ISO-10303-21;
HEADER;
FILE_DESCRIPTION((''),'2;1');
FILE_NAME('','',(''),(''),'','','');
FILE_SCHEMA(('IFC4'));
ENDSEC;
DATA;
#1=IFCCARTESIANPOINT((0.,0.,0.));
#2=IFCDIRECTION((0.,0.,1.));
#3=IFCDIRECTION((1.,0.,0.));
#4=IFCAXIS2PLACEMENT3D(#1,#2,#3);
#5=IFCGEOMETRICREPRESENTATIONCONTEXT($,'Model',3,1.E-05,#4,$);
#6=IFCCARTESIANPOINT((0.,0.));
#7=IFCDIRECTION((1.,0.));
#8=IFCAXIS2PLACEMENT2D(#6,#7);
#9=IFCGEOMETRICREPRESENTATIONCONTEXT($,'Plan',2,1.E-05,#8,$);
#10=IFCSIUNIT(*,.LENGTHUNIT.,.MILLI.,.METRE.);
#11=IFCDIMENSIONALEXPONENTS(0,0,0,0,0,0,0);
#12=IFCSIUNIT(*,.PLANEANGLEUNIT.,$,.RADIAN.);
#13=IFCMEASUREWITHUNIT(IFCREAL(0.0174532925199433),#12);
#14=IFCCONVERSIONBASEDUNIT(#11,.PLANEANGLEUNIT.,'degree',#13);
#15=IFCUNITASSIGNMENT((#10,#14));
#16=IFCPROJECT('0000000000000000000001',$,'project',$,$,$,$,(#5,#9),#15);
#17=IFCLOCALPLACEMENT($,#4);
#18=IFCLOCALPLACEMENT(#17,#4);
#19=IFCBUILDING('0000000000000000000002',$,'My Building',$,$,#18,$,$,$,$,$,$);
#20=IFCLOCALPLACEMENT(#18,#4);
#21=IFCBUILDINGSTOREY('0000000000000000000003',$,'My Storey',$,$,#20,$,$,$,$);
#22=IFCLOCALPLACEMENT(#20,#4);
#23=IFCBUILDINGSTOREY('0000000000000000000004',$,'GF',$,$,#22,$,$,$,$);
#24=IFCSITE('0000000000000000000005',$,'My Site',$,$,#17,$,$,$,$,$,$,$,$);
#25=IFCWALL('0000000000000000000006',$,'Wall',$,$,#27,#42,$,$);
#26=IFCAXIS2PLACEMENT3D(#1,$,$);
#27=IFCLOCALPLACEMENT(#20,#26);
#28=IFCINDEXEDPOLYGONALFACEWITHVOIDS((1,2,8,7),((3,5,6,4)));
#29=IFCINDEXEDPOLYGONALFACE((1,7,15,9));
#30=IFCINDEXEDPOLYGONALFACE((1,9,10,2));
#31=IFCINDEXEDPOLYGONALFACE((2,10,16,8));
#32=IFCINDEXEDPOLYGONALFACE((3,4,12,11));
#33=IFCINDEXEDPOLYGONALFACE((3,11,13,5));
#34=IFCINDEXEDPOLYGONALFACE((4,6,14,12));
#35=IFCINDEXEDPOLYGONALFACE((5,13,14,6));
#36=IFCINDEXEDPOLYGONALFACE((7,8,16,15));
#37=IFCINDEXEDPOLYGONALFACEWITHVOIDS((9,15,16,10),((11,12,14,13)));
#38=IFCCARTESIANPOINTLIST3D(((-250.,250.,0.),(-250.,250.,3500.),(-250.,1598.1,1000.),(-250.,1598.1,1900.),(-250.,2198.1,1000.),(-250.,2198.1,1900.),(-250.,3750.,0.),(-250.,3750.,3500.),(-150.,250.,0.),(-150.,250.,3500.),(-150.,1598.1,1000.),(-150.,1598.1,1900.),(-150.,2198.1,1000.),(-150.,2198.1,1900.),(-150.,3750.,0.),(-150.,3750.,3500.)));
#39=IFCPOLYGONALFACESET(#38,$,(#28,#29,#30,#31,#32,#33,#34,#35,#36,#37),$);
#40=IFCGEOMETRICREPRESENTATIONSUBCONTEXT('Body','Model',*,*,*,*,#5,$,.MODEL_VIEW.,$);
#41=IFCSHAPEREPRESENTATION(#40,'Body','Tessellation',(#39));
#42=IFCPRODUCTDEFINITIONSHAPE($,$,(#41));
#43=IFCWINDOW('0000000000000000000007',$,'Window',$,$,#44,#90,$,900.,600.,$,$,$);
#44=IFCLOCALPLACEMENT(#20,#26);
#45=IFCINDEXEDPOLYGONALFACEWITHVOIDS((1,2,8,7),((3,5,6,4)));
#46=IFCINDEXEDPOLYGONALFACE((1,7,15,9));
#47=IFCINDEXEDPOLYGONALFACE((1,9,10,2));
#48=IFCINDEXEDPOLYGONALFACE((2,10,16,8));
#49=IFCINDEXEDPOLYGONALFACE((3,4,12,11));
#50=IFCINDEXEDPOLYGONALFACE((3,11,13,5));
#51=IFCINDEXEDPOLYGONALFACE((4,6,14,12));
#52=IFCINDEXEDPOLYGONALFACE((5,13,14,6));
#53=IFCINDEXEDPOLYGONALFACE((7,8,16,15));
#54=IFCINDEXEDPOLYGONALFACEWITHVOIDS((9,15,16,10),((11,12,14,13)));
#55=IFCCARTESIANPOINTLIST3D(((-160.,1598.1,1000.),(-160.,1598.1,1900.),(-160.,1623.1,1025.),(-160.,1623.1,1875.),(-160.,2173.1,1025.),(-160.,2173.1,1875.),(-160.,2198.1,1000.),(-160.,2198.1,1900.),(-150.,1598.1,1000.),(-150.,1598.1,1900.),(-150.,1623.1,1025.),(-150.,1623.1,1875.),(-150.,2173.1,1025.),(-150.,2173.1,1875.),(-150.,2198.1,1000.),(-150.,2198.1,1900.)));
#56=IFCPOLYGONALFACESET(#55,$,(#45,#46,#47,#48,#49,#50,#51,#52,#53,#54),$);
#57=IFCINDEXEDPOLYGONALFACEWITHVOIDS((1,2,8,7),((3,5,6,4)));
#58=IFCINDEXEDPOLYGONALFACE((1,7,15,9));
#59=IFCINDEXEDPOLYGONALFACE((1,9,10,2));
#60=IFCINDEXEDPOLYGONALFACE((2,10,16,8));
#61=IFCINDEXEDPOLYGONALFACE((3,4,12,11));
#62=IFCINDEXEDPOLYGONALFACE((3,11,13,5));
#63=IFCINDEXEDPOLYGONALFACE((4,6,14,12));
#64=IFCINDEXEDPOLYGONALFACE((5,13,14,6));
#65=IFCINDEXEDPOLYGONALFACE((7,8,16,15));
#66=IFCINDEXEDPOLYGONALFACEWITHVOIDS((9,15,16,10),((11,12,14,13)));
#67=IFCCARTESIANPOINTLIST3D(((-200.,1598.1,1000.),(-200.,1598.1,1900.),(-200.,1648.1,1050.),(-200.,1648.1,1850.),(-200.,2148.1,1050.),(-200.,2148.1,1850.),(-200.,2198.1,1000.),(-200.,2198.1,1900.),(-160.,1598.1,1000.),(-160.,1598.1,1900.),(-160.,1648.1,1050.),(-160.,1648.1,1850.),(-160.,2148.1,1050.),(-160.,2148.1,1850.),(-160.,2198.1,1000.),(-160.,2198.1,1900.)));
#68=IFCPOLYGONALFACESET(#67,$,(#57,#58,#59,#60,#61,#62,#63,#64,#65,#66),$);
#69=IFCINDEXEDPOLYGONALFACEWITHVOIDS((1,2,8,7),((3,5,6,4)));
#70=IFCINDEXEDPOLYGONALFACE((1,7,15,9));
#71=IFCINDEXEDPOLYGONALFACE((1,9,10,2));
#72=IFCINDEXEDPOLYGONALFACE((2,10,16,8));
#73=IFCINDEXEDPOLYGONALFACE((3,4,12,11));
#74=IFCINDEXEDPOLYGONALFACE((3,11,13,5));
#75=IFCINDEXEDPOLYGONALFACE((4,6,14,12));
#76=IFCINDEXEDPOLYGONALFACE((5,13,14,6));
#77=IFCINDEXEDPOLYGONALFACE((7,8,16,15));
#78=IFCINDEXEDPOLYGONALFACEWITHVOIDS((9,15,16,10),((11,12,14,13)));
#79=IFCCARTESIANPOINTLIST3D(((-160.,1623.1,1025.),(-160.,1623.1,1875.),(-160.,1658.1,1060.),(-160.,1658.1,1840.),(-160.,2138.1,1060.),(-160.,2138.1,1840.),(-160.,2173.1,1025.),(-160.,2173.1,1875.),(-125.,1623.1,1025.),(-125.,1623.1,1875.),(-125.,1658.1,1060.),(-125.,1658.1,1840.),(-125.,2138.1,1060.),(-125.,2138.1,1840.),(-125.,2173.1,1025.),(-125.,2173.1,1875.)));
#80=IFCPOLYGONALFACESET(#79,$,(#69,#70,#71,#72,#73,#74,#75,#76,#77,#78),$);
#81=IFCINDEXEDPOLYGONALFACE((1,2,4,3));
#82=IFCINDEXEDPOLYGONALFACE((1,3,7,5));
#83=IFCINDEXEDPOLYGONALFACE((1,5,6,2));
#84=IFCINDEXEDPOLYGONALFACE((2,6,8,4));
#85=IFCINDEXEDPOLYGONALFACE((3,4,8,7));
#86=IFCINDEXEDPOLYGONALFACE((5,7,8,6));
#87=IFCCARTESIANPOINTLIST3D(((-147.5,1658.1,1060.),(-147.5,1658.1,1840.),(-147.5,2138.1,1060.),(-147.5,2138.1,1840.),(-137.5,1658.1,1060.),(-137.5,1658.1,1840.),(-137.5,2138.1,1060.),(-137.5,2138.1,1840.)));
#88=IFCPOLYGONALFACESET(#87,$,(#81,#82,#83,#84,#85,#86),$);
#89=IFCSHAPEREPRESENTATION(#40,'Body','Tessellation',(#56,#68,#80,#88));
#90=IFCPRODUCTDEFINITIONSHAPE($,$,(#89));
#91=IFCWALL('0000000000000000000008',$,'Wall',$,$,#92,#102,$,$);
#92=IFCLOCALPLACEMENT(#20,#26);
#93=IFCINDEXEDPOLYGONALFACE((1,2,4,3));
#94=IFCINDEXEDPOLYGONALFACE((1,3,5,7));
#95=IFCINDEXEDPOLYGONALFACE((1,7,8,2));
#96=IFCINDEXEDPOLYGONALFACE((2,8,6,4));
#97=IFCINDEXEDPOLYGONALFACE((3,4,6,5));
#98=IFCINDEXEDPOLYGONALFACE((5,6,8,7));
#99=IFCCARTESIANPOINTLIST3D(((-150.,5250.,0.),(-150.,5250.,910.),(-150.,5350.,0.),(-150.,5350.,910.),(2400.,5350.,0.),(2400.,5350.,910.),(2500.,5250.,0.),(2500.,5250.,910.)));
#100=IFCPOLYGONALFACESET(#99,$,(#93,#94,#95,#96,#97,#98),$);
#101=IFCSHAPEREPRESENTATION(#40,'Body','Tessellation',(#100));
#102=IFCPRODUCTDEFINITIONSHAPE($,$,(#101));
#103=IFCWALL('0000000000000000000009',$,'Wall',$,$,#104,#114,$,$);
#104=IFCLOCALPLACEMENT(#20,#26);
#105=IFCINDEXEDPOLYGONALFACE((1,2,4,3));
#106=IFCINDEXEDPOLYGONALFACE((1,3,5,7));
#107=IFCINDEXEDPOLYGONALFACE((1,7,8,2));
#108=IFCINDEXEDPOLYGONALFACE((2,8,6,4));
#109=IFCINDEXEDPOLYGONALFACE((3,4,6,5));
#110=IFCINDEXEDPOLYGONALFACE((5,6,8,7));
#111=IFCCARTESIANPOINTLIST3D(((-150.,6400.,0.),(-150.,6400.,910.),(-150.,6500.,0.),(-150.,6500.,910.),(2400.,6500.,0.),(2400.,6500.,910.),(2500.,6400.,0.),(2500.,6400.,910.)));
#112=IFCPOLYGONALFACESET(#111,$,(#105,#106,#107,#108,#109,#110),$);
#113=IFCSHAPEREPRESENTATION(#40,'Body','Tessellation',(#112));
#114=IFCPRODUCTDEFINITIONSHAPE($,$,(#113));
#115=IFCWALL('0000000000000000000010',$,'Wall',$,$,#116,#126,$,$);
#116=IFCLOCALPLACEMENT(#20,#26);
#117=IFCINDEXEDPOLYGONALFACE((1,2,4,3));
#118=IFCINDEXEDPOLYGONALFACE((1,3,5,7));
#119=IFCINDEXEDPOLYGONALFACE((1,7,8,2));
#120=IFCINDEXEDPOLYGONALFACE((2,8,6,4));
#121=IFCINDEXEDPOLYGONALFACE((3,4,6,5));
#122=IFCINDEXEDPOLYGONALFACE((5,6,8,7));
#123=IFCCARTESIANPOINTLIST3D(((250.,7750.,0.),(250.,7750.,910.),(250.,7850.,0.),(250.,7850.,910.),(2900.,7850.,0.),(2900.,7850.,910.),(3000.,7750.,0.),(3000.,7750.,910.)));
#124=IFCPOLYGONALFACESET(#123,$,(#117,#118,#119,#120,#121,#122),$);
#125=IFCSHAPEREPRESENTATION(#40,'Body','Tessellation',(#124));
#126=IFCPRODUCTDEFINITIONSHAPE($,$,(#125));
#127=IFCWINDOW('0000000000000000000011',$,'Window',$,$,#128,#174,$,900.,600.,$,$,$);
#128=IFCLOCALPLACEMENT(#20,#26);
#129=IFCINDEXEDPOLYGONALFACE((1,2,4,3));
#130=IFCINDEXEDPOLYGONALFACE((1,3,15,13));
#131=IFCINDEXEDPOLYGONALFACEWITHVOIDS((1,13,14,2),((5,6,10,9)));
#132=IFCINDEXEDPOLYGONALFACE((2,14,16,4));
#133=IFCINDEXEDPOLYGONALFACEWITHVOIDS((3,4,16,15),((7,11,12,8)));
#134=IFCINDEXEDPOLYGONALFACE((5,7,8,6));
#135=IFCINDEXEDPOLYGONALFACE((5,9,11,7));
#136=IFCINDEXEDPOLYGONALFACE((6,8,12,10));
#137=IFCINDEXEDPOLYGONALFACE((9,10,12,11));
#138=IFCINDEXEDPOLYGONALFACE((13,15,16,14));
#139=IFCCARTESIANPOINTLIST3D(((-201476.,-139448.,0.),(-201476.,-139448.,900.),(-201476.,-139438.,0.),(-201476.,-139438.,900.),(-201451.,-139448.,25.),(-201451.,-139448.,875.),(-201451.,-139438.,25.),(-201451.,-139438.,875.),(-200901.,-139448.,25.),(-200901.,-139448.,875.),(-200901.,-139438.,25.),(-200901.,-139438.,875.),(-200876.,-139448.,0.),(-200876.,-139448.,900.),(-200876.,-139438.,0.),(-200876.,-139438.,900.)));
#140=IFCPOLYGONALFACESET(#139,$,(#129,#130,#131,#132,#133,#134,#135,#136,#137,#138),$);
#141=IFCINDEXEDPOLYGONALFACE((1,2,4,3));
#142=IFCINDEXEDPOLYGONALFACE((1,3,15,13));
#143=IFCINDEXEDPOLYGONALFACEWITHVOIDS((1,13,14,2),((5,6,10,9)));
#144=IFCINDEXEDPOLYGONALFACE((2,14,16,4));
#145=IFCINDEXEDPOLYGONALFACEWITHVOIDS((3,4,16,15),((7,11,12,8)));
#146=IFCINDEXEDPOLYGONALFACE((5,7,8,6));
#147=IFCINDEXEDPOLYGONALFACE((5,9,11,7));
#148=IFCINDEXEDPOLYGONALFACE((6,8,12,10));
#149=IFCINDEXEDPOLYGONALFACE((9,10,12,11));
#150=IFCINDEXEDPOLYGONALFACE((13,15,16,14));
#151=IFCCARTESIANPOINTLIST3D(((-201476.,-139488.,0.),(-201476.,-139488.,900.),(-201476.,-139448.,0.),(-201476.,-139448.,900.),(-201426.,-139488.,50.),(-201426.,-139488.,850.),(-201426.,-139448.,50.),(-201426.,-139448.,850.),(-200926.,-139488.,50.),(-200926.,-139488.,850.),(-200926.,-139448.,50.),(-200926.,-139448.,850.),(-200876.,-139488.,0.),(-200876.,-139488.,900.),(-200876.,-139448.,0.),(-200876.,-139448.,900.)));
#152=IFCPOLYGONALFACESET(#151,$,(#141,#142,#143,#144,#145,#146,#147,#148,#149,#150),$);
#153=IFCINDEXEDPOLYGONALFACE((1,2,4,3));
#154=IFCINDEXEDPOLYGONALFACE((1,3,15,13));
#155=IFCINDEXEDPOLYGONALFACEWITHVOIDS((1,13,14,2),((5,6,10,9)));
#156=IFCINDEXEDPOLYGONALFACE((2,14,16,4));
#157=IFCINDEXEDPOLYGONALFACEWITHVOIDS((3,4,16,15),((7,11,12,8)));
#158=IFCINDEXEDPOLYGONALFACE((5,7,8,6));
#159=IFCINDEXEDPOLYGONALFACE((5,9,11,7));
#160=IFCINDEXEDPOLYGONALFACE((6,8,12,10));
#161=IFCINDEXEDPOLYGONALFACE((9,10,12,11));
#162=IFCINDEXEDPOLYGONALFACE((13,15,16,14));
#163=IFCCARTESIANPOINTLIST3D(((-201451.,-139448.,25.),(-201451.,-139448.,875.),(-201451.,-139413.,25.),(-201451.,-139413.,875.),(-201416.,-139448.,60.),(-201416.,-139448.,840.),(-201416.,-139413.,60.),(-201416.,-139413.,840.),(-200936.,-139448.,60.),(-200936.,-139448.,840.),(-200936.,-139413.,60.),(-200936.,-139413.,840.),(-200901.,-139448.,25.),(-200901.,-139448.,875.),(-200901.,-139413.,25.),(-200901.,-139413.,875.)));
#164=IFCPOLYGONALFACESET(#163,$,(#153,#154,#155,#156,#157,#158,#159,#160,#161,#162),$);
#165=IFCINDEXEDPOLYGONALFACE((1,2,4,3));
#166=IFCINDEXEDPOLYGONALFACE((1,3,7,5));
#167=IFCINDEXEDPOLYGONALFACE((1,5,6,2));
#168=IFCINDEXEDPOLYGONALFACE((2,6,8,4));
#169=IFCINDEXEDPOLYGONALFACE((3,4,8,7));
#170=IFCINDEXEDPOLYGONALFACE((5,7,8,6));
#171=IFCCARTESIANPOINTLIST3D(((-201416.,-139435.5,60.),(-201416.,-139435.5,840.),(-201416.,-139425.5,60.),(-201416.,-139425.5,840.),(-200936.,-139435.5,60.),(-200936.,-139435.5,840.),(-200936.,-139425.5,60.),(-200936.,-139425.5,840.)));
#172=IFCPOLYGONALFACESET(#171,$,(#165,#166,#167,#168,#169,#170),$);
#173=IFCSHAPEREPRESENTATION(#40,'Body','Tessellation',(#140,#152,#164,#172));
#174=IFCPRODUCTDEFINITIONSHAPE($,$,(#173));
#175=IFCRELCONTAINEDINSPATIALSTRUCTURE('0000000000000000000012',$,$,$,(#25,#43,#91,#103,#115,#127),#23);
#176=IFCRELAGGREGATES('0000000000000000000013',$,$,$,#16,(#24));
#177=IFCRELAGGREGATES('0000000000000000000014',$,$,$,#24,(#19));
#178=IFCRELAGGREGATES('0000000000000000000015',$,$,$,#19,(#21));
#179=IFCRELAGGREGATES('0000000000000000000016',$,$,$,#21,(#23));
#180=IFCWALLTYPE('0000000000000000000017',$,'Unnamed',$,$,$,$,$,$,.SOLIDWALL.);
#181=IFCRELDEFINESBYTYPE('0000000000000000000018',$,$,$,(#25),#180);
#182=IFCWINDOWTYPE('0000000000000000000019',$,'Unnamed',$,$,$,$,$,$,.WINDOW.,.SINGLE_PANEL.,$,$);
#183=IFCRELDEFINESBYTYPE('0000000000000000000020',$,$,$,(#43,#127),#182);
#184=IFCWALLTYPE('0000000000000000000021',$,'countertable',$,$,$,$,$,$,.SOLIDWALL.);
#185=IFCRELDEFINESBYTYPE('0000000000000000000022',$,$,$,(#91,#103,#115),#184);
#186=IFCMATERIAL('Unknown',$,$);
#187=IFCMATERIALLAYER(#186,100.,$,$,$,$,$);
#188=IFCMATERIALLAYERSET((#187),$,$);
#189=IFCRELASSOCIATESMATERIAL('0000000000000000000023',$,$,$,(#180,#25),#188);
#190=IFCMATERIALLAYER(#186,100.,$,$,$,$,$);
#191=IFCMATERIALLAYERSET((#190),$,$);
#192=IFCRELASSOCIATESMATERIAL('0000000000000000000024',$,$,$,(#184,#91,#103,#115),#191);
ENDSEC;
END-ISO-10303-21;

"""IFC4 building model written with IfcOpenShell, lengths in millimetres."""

from ifc_helpers import new_model, entity, si_unit, converted_unit, frame, origin_with_axes, origin_2d_with_axis, place, context, subcontext, project, spatial, line, indexed_curve, outline, extrude, shape, source, transform, mapped, material, layer, layer_set, layer_usage, type_object, type_shapes, element, fill, save


model = new_model("IFC4")

# Units and contexts
model_context = context("Model", 3, precision=1e-05, world=origin_with_axes())
plan_context = context("Plan", 2, precision=1e-05, world=origin_2d_with_axis())
body_context_1 = subcontext(model_context, "Body", "Model", "MODEL_VIEW")
body_context_2 = subcontext(plan_context, "Body", "Plan", "PLAN_VIEW")
ifc_project = project(units=[si_unit("LENGTHUNIT", "METRE", prefix="MILLI"), converted_unit("PLANEANGLEUNIT", "degree", entity("IfcReal", 0.0174532925199433), si_unit("PLANEANGLEUNIT", "RADIAN"), dimensions=[0, 0, 0, 0, 0, 0, 0])], contexts=[model_context, plan_context])

# Site, building, storeys
site_placement = place(None, origin_with_axes())
site = spatial("IfcSite", under=ifc_project, at=site_placement, Name="My Site")
building_placement = place(site_placement, origin_with_axes())
building = spatial("IfcBuilding", under=site, at=building_placement, Name="My Building")
storey_1_placement = place(building_placement, origin_with_axes())
storey_1 = spatial("IfcBuildingStorey", under=building, at=storey_1_placement, Name="My Storey")
storey_2_placement = place(storey_1_placement, origin_with_axes())
storey_2 = spatial("IfcBuildingStorey", under=storey_1, at=storey_2_placement, Name="GF")

# Shared definitions
ifc_material = material(Name="Unknown")

# Shared definitions
ifc_layer_1 = layer(ifc_material, 100.0)
ifc_layer_set_1 = layer_set([ifc_layer_1])
wall_type_1 = type_object("IfcWallType", Name="Unnamed", PredefinedType="SOLIDWALL", material=ifc_layer_set_1)

# Shared definitions
shared_shape_1 = source(origin_with_axes(), body_context_1, "Body", "SweptSolid", [
    extrude(outline(indexed_curve([(0.0, 0.0), (600.0, 0.0), (600.0, 900.0), (0.0, 900.0)], segments=[line(1, 2, 3, 4, 1)])), frame((0.0, -600.0, 0.0), z_axis=(0.0, -1.0, 0.0), x_axis=(1.0, 0.0, 0.0)), (0.0, 0.0, -1.0), 1200.0),
])
window_type = type_object("IfcWindowType", Name="Unnamed", PartitioningType="SINGLE_PANEL", PredefinedType="WINDOW")
shared_shape_2 = source(origin_with_axes(), body_context_1, "Body", "SweptSolid", [
    extrude(outline(indexed_curve([(0.0, 0.0), (600.0, 0.0), (600.0, 900.0), (0.0, 900.0)], segments=[line(1, 2, 3, 4, 1)]), holes=[indexed_curve([(25.0, 25.0), (575.0, 25.0), (575.0, 875.0), (25.0, 875.0)], segments=[line(1, 2, 3, 4, 1)])]), frame((0.0, 90.0, 0.0), z_axis=(0.0, -1.0, 0.0), x_axis=(1.0, 0.0, 0.0)), (0.0, 0.0, -1.0), 10.0),
    extrude(outline(indexed_curve([(0.0, 0.0), (600.0, 0.0), (600.0, 900.0), (0.0, 900.0)], segments=[line(1, 2, 3, 4, 1)]), holes=[indexed_curve([(50.0, 50.0), (550.0, 50.0), (550.0, 850.0), (50.0, 850.0)], segments=[line(1, 2, 3, 4, 1)])]), frame((0.0, 50.0, 0.0), z_axis=(0.0, -1.0, 0.0), x_axis=(1.0, 0.0, 0.0)), (0.0, 0.0, -1.0), 40.0),
    extrude(outline(indexed_curve([(0.0, 0.0), (550.0, 0.0), (550.0, 850.0), (0.0, 850.0)], segments=[line(1, 2, 3, 4, 1)]), holes=[indexed_curve([(35.0, 35.0), (515.0, 35.0), (515.0, 815.0), (35.0, 815.0)], segments=[line(1, 2, 3, 4, 1)])]), frame((25.0, 90.0, 25.0), z_axis=(0.0, -1.0, 0.0), x_axis=(1.0, 0.0, 0.0)), (0.0, 0.0, -1.0), 35.0),
    extrude(outline(indexed_curve([(35.0, 35.0), (515.0, 35.0), (515.0, 815.0), (35.0, 815.0)], segments=[line(1, 2, 3, 4, 1)])), frame((25.0, 102.5, 25.0), z_axis=(0.0, -1.0, 0.0), x_axis=(1.0, 0.0, 0.0)), (0.0, 0.0, -1.0), 10.0),
])
shared_shape_3 = source(origin_with_axes(), body_context_2, "Body", "Curve2D", [
    entity("IfcIndexedPolyCurve", entity("IfcCartesianPointList2D", [[50.0, 50.0], [550.0, 50.0]])),
    entity("IfcIndexedPolyCurve", entity("IfcCartesianPointList2D", [[0.0, 100.0], [25.0, 100.0], [25.0, 90.0], [50.0, 90.0], [50.0, 50.0], [0.0, 50.0]]), [entity("IfcLineIndex", [1, 2, 3, 4, 5, 6, 1])]),
    entity("IfcIndexedPolyCurve", entity("IfcCartesianPointList2D", [[600.0, 100.0], [575.0, 100.0], [575.0, 90.0], [550.0, 90.0], [550.0, 50.0], [600.0, 50.0]]), [entity("IfcLineIndex", [1, 2, 3, 4, 5, 6, 1])]),
    entity("IfcIndexedPolyCurve", entity("IfcCartesianPointList2D", [[25.0, 90.0], [60.0, 90.0], [60.0, 125.0], [25.0, 125.0]]), [entity("IfcLineIndex", [1, 2, 3, 4, 1])]),
    entity("IfcIndexedPolyCurve", entity("IfcCartesianPointList2D", [[575.0, 90.0], [540.0, 90.0], [540.0, 125.0], [575.0, 125.0]]), [entity("IfcLineIndex", [1, 2, 3, 4, 1])]),
    entity("IfcIndexedPolyCurve", entity("IfcCartesianPointList2D", [[60.0, 90.0], [540.0, 90.0]])),
    entity("IfcIndexedPolyCurve", entity("IfcCartesianPointList2D", [[60.0, 125.0], [540.0, 125.0]])),
    entity("IfcIndexedPolyCurve", entity("IfcCartesianPointList2D", [[60.0, 107.5], [540.0, 107.5]])),
])
type_shapes(window_type, [shared_shape_2, shared_shape_3])

# Wall, opening, window
ifc_layer_usage_1 = layer_usage(ifc_layer_set_1, "AXIS2", "POSITIVE", 0.0)
wall_1_placement = place(storey_2_placement, frame((-250.0, 3750.0, 0.0), z_axis=(0.0, 0.0, 1.0), x_axis=(0.0, -1.0, 0.0)))
wall_1 = element("IfcWall", 1, at=wall_1_placement, inside=storey_2, type_object=wall_type_1, material=ifc_layer_usage_1, Name="Wall", context=body_context_1, shape_type="SweptSolid", body=[
    extrude(outline(indexed_curve([(0.0, 0.0), (0.0, 100.0), (3500.0, 100.0), (3500.0, 0.0)], segments=[line(1, 2, 3, 4, 1)])), origin_with_axes(), (0.0, 0.0, 1.0), 3500.0),
])
opening_1_placement = place(wall_1_placement, frame((1551.9, 0.0, 1000.0), z_axis=(0.0, 0.0, 1.0), x_axis=(1.0, 0.0, 0.0)))
opening_1 = element("IfcOpeningElement", 2, at=opening_1_placement, cuts=wall_1, PredefinedType="OPENING", context=body_context_1, shape_type="MappedRepresentation", body=[
    mapped(shared_shape_1, transform((0.0, 0.0, 0.0), x_axis=(1.0, 0.0, 0.0), y_axis=(0.0, 1.0, 0.0), z_axis=(0.0, 0.0, 1.0), scale=1.0)),
])
window_1_placement = place(opening_1_placement, frame((0.0, 0.0, 0.0), z_axis=(0.0, 0.0, 1.0), x_axis=(1.0, 0.0, 0.0)))
window_1 = element("IfcWindow", 3, at=window_1_placement, inside=storey_2, type_object=window_type, Name="Window", OverallHeight=900.0, OverallWidth=600.0, shapes=[
    shape(body_context_1, "Body", "MappedRepresentation", [mapped(shared_shape_2, transform((0.0, 0.0, 0.0), x_axis=(1.0, 0.0, 0.0), y_axis=(0.0, 1.0, 0.0), z_axis=(0.0, 0.0, 1.0), scale=1.0))]),
    shape(body_context_2, "Body", "MappedRepresentation", [mapped(shared_shape_3, transform((0.0, 0.0, 0.0), x_axis=(1.0, 0.0, 0.0), y_axis=(0.0, 1.0, 0.0), z_axis=(0.0, 0.0, 1.0), scale=1.0))]),
])
fill(opening_1, window_1)

# Walls
ifc_layer_2 = layer(ifc_material, 100.0)
ifc_layer_set_2 = layer_set([ifc_layer_2])
ifc_layer_usage_2 = layer_usage(ifc_layer_set_2, "AXIS2", "POSITIVE", 0.0)
wall_type_2 = type_object("IfcWallType", Name="countertable", PredefinedType="SOLIDWALL", material=ifc_layer_set_2)
wall_2_placement = place(storey_2_placement, frame((-150.0, 5250.0, 0.0), z_axis=(0.0, 0.0, 1.0), x_axis=(1.0, 0.0, 0.0)))
element("IfcWall", 4, at=wall_2_placement, inside=storey_2, type_object=wall_type_2, material=ifc_layer_usage_2, Name="Wall", context=body_context_1, shape_type="SweptSolid", body=[
    extrude(outline(indexed_curve([(0.0, 0.0), (0.0, 100.0), (2550.0, 100.0), (2650.0, 0.0)], segments=[line(1, 2, 3, 4, 1)])), origin_with_axes(), (0.0, 0.0, 1.0), 910.0),
])
ifc_layer_usage_3 = layer_usage(ifc_layer_set_2, "AXIS2", "POSITIVE", 0.0)
wall_3_placement = place(storey_2_placement, frame((-150.0, 6400.0, 0.0), z_axis=(0.0, 0.0, 1.0), x_axis=(1.0, 0.0, 0.0)))
element("IfcWall", 5, at=wall_3_placement, inside=storey_2, type_object=wall_type_2, material=ifc_layer_usage_3, Name="Wall", context=body_context_1, shape_type="SweptSolid", body=[
    extrude(outline(indexed_curve([(0.0, 0.0), (0.0, 100.0), (2550.0, 100.0), (2650.0, 0.0)], segments=[line(1, 2, 3, 4, 1)])), origin_with_axes(), (0.0, 0.0, 1.0), 910.0),
])
ifc_layer_usage_4 = layer_usage(ifc_layer_set_2, "AXIS2", "POSITIVE", 0.0)
wall_4_placement = place(storey_2_placement, frame((250.0, 7750.0, 0.0), z_axis=(0.0, 0.0, 1.0), x_axis=(1.0, 0.0, 0.0)))
element("IfcWall", 6, at=wall_4_placement, inside=storey_2, type_object=wall_type_2, material=ifc_layer_usage_4, Name="Wall", context=body_context_1, shape_type="SweptSolid", body=[
    extrude(outline(indexed_curve([(0.0, 0.0), (0.0, 100.0), (2650.0, 100.0), (2750.0, 0.0)], segments=[line(1, 2, 3, 4, 1)])), origin_with_axes(), (0.0, 0.0, 1.0), 910.0),
])

# Window
window_2_placement = place(storey_2_placement, frame((-201476.0, -139538.0, 0.0), z_axis=(0.0, 0.0, 1.0), x_axis=(1.0, 0.0, 0.0)))
element("IfcWindow", 7, at=window_2_placement, inside=storey_2, type_object=window_type, Name="Window", OverallHeight=900.0, OverallWidth=600.0, shapes=[
    shape(body_context_1, "Body", "MappedRepresentation", [mapped(shared_shape_2, transform((0.0, 0.0, 0.0), x_axis=(1.0, 0.0, 0.0), y_axis=(0.0, 1.0, 0.0), z_axis=(0.0, 0.0, 1.0), scale=1.0))]),
    shape(body_context_2, "Body", "MappedRepresentation", [mapped(shared_shape_3, transform((0.0, 0.0, 0.0), x_axis=(1.0, 0.0, 0.0), y_axis=(0.0, 1.0, 0.0), z_axis=(0.0, 0.0, 1.0), scale=1.0))]),
])

save(model, "model.ifc")
